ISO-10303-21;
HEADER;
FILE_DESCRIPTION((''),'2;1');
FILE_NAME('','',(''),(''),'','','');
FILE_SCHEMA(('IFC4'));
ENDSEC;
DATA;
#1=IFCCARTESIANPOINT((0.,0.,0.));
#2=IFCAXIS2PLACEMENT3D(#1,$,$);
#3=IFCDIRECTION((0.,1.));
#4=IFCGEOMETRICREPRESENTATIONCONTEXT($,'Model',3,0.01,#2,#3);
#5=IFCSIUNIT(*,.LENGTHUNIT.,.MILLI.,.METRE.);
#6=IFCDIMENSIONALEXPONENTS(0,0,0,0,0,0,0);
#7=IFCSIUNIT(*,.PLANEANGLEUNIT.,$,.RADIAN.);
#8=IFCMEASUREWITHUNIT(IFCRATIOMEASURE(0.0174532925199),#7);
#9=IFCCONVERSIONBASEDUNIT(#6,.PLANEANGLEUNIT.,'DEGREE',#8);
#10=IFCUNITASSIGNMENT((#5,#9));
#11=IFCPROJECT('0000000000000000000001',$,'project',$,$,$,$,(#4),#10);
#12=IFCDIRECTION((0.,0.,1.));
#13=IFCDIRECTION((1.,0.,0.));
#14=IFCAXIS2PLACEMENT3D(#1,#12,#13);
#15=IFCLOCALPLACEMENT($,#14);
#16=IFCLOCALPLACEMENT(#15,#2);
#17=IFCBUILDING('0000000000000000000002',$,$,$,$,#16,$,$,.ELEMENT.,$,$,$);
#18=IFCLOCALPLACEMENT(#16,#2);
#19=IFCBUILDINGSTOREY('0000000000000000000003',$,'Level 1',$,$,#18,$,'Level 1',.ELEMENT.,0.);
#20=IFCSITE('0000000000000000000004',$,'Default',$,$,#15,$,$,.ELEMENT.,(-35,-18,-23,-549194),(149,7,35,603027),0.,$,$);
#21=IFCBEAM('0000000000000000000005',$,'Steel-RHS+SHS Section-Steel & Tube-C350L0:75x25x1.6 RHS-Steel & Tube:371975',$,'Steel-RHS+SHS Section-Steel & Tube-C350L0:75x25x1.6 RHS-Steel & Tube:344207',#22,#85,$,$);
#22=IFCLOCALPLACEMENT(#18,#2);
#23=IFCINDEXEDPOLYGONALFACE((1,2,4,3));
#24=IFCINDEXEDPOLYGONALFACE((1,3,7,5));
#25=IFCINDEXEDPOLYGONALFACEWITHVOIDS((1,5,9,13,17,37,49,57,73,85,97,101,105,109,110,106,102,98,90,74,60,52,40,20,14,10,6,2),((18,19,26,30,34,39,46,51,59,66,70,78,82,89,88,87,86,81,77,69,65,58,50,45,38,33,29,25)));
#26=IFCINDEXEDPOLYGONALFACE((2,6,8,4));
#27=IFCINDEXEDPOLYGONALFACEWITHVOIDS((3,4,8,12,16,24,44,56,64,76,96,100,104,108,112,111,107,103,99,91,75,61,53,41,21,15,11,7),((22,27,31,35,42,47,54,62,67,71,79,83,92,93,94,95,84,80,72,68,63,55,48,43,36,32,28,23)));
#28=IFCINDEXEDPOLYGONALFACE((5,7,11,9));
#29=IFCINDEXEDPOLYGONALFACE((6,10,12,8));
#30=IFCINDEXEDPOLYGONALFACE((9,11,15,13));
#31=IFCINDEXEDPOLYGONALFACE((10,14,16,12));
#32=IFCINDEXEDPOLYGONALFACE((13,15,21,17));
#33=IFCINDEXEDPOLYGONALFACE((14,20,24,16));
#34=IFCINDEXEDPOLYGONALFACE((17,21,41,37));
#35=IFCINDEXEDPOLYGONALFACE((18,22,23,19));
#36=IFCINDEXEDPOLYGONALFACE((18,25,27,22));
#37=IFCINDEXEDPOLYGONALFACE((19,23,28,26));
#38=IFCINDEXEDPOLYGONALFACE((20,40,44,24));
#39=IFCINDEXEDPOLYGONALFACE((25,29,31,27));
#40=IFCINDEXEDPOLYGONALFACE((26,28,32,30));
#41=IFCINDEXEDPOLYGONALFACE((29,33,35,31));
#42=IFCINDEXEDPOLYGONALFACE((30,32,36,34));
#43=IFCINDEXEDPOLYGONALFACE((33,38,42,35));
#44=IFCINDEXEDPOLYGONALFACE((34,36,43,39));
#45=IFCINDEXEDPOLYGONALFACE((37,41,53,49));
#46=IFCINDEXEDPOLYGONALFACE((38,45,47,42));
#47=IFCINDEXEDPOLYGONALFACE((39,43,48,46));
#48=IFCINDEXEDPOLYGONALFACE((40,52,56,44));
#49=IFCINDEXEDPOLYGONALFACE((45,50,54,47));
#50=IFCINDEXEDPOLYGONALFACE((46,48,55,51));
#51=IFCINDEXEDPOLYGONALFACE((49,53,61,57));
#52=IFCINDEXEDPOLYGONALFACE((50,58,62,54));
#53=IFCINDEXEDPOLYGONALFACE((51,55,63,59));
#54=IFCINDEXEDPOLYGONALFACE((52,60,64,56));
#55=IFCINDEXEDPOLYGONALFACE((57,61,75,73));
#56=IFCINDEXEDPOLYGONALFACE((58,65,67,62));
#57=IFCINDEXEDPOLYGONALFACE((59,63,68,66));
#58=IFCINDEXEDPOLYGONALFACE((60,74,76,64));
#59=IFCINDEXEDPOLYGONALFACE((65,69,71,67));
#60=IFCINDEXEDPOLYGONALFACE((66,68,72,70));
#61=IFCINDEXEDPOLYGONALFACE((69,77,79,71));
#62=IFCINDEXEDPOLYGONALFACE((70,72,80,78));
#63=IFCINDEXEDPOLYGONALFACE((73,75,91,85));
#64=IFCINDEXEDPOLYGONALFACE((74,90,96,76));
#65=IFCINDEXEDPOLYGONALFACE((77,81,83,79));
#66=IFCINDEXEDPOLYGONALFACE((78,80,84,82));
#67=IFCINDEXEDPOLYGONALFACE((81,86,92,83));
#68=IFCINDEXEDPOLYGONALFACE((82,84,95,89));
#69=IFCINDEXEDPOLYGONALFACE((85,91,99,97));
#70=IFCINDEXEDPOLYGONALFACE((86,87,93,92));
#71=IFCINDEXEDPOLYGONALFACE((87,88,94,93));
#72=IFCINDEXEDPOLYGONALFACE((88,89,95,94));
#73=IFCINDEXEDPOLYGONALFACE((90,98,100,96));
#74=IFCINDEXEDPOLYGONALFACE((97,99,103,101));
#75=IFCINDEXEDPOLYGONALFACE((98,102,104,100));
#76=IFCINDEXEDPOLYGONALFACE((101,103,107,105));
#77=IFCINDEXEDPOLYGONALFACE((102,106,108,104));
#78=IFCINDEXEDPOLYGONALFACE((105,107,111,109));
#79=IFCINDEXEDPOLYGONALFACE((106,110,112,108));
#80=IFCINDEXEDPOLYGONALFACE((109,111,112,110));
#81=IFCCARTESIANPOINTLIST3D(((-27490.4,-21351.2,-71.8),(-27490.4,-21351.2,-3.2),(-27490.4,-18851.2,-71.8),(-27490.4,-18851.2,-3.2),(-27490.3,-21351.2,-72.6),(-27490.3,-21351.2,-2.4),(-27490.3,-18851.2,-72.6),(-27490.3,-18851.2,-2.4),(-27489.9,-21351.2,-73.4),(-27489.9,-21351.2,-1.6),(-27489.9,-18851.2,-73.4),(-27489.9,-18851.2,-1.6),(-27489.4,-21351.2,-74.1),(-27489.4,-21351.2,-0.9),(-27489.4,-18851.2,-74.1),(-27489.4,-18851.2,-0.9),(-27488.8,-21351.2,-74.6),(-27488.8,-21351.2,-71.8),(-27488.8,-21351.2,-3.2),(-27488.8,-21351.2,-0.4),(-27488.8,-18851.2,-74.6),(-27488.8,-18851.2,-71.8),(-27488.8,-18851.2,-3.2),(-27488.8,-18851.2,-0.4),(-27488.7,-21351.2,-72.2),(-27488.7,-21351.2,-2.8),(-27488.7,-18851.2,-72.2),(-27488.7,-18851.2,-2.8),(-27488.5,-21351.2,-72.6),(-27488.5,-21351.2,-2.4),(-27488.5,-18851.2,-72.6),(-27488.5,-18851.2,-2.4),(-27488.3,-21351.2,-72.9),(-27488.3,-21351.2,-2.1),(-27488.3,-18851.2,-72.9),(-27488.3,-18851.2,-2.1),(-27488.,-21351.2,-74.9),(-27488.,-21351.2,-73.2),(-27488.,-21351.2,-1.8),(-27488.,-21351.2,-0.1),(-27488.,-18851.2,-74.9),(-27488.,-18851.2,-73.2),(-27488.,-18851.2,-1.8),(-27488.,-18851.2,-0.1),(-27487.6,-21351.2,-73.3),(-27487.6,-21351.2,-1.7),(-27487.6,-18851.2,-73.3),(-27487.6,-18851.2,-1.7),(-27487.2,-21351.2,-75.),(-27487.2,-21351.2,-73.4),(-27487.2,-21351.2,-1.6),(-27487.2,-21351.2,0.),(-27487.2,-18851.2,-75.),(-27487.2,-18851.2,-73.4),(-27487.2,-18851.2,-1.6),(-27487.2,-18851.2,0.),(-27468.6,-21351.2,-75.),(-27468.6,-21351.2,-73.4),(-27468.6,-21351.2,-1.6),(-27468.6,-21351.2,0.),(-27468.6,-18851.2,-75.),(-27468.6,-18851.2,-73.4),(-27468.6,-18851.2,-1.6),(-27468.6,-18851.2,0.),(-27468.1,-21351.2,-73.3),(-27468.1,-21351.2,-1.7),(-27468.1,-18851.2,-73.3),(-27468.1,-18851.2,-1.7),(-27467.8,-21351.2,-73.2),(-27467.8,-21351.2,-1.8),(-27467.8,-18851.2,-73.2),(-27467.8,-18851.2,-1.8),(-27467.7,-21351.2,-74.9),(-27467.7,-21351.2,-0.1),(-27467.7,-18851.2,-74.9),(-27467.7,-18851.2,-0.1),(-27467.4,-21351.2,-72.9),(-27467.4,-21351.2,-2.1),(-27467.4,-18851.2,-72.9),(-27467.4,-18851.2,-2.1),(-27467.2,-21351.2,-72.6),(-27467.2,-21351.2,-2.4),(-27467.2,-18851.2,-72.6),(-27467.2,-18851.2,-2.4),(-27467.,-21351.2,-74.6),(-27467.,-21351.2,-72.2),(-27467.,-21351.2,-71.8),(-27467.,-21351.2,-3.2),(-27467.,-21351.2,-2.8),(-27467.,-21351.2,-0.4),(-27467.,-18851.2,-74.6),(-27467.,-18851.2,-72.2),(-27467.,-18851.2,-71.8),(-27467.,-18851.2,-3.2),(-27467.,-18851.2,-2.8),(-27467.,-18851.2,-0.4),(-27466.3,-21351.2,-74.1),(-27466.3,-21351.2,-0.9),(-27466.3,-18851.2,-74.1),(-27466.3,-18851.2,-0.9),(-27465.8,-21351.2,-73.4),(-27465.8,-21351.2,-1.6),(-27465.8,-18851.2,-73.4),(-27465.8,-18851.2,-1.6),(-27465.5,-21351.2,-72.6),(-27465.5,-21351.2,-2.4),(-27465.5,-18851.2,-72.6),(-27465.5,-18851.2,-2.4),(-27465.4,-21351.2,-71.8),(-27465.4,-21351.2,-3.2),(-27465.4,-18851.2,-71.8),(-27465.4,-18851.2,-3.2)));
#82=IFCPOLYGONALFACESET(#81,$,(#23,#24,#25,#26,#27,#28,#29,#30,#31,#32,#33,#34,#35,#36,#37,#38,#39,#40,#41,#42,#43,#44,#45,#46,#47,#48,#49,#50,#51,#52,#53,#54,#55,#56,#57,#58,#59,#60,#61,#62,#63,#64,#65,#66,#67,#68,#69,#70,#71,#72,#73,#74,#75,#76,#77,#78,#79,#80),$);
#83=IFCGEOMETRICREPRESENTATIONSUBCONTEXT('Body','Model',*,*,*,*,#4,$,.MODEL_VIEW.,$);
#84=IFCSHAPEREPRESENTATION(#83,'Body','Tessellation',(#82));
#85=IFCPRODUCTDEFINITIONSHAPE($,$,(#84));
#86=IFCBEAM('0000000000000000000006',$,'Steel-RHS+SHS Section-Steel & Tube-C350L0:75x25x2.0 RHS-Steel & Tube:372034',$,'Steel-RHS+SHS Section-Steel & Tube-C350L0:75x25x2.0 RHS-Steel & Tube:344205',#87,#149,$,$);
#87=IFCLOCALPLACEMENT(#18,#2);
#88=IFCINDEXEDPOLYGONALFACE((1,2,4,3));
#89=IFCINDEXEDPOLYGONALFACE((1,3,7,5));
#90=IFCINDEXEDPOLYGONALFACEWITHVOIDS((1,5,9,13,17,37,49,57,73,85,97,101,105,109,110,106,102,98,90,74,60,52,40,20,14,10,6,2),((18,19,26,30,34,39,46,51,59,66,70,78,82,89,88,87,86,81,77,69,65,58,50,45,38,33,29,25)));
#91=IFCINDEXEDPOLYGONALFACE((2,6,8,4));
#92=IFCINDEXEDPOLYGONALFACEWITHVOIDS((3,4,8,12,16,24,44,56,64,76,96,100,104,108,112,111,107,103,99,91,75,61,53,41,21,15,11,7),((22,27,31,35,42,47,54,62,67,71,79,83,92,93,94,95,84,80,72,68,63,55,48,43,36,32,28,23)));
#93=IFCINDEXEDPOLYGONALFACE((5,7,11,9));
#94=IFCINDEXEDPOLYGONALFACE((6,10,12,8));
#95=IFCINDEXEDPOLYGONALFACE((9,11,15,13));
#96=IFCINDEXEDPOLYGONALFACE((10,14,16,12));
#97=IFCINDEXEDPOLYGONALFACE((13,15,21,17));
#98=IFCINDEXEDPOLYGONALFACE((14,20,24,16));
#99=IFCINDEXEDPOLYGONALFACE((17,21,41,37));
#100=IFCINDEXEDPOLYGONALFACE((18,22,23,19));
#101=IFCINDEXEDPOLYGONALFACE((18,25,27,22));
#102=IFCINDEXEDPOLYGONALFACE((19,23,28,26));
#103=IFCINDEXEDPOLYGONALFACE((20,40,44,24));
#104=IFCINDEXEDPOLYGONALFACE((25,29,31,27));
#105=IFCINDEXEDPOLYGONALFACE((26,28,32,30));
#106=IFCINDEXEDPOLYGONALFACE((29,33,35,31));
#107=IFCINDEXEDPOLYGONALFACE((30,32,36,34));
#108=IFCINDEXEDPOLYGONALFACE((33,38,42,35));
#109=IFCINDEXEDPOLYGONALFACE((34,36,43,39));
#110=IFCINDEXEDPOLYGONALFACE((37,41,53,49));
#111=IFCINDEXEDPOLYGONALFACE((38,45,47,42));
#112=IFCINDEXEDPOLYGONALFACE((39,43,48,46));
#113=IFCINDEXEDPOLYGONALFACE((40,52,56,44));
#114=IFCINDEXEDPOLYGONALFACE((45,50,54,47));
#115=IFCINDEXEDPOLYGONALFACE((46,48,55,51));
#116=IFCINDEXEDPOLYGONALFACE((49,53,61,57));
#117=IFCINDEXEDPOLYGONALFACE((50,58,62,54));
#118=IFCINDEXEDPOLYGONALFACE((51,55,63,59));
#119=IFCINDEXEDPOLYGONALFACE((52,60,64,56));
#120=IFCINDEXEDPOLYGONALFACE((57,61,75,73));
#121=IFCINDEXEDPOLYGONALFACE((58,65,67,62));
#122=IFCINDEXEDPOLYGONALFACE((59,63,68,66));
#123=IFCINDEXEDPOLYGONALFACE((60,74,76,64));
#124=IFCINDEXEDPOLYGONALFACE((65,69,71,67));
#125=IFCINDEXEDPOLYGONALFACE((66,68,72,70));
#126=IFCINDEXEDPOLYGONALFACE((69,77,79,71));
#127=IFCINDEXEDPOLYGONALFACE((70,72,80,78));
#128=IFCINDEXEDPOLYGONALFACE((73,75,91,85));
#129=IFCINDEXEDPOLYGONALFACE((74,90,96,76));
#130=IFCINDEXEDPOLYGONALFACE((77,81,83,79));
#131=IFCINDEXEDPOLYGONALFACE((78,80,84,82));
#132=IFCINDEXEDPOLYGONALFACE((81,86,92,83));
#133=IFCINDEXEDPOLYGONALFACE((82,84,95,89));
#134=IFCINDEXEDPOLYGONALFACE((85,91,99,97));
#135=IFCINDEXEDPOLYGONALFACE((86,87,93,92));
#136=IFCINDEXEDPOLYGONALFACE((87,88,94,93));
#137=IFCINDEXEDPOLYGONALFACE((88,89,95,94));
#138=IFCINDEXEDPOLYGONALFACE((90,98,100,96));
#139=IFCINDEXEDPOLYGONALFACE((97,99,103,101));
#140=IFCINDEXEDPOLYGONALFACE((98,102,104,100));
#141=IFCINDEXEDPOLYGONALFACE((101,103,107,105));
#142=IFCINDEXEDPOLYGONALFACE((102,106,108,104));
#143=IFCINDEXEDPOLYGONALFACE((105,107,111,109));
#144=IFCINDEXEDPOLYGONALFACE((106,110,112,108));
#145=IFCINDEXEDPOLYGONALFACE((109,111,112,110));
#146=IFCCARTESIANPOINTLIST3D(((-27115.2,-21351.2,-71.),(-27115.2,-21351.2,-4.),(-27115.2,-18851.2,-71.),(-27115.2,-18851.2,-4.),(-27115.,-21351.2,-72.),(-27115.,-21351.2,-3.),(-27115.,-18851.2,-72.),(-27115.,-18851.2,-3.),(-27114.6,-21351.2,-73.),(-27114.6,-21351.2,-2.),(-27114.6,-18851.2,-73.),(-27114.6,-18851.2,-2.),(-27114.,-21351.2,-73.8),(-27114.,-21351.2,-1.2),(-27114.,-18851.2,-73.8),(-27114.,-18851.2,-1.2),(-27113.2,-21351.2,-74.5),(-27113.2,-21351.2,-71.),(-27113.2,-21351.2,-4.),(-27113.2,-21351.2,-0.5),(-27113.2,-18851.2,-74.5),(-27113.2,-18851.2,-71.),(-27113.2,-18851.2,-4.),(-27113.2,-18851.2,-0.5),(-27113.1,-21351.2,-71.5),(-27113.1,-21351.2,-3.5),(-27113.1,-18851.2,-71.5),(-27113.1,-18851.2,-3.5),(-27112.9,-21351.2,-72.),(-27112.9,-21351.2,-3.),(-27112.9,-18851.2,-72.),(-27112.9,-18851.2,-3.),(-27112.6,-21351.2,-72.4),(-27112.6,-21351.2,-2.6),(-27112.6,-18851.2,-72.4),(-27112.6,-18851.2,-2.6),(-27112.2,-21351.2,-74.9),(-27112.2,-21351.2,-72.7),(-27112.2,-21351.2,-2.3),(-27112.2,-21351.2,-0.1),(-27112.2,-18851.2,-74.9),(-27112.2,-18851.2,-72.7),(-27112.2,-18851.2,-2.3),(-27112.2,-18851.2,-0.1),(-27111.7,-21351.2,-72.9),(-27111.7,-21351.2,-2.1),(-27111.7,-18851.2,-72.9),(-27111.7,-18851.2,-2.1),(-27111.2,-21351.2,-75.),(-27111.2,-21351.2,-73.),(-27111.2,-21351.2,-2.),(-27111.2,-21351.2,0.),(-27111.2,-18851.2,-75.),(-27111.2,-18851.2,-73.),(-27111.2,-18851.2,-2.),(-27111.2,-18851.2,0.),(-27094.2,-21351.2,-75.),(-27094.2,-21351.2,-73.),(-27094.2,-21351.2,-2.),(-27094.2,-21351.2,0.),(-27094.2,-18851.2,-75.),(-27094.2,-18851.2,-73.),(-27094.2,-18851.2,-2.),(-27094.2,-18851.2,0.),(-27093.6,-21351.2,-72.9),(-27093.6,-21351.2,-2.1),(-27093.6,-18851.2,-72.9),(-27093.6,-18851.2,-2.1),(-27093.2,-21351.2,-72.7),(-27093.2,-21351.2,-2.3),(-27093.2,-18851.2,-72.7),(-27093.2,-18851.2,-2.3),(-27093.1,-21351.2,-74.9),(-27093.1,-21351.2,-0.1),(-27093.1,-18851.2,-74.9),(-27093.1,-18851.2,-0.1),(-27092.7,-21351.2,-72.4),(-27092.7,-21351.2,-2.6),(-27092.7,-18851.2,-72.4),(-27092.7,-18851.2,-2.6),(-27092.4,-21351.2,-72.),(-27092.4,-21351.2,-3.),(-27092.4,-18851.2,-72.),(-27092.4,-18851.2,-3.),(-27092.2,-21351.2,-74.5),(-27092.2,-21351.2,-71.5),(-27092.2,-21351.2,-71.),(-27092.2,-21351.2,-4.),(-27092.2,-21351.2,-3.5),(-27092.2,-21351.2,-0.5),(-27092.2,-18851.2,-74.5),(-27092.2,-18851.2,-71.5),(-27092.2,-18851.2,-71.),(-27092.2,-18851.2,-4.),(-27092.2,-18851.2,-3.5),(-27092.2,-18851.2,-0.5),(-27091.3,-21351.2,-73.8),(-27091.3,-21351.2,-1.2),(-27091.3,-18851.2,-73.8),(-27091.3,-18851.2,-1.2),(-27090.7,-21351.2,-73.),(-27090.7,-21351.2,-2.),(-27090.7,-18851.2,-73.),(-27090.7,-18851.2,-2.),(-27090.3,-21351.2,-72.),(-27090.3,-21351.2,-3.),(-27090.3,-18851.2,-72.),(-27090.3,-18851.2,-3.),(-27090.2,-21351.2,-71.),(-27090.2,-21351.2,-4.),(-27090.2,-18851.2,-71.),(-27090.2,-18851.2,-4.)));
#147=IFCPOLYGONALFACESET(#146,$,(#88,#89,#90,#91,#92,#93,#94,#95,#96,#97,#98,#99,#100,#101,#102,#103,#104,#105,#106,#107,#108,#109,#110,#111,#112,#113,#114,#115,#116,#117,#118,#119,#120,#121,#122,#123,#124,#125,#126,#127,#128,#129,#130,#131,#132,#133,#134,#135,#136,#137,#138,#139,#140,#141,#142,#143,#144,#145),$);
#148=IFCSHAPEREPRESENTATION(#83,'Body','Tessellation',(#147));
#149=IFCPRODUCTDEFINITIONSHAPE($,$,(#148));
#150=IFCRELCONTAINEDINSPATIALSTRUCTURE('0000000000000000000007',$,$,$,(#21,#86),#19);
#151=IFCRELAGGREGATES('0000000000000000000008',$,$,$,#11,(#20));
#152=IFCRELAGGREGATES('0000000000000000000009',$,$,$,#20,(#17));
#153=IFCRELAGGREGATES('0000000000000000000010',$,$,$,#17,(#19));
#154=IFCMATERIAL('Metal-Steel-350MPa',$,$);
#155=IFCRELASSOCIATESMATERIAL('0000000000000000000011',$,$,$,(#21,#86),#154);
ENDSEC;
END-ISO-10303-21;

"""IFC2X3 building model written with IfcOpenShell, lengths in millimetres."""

from ifc_helpers import new_model, entity, si_unit, converted_unit, direction, frame, frame_2d, origin, origin_with_axes, place, context, subcontext, project, spatial, polyline, circle_curve, parameter, trimmed, segment, composite_curve, outline, extrude, material, element, save


model = new_model("IFC2X3")

# Units and contexts
model_context = context("Model", 3, precision=0.01, world=origin(), true_north=direction((0.0, 1.0)))
body_context = subcontext(model_context, "Body", "Model", "MODEL_VIEW")
ifc_project = project(units=[si_unit("LENGTHUNIT", "METRE", prefix="MILLI"), converted_unit("PLANEANGLEUNIT", "DEGREE", entity("IfcRatioMeasure", 0.0174532925199), si_unit("PLANEANGLEUNIT", "RADIAN"), dimensions=[0, 0, 0, 0, 0, 0, 0])], contexts=[model_context])

# Site, building, storey
site_placement = place(None, origin_with_axes())
site = spatial("IfcSite", under=ifc_project, at=site_placement, Name="Default", CompositionType="ELEMENT", RefLatitude=(-35, -18, -23, -549194), RefLongitude=(149, 7, 35, 603027), RefElevation=0.0)
building_placement = place(site_placement, origin())
building = spatial("IfcBuilding", under=site, at=building_placement, CompositionType="ELEMENT")
storey_placement = place(building_placement, origin())
storey = spatial("IfcBuildingStorey", under=building, at=storey_placement, Name="Level 1", LongName="Level 1", CompositionType="ELEMENT", Elevation=0.0)

# Beams
ifc_material = material(Name="Metal-Steel-350MPa")
beam_1_placement = place(storey_placement, frame((-27477.9, -18851.2, 0.0), z_axis=(0.0, 0.0, 1.0), x_axis=(0.0, -1.0, 0.0)))
element("IfcBeam", 1, at=beam_1_placement, inside=storey, material=ifc_material, Name="Steel-RHS+SHS Section-Steel & Tube-C350L0:75x25x1.6 RHS-Steel & Tube:371975", ObjectType="Steel-RHS+SHS Section-Steel & Tube-C350L0:75x25x1.6 RHS-Steel & Tube:344207", context=body_context, shape_type="SweptSolid", body=[
    extrude(outline(composite_curve([segment(trimmed(circle_curve(frame_2d((-9.3, -34.3), x_axis=(1.0, 0.0)), 3.2), [parameter(180.0)], [parameter(270.0)], True, "PARAMETER"), True, "CONTINUOUS"), segment(polyline([(-9.3, -37.5), (9.3, -37.5)]), True, "CONTINUOUS"), segment(trimmed(circle_curve(frame_2d((9.3, -34.3), x_axis=(1.0, 0.0)), 3.2), [parameter(270.0)], [parameter(0.0)], True, "PARAMETER"), True, "CONTINUOUS"), segment(polyline([(12.5, -34.3), (12.5, 34.3)]), True, "CONTINUOUS"), segment(trimmed(circle_curve(frame_2d((9.3, 34.3), x_axis=(1.0, 0.0)), 3.2), [parameter(0.0)], [parameter(90.0)], True, "PARAMETER"), True, "CONTINUOUS"), segment(polyline([(9.3, 37.5), (-9.3, 37.5)]), True, "CONTINUOUS"), segment(trimmed(circle_curve(frame_2d((-9.3, 34.3), x_axis=(1.0, 0.0)), 3.2), [parameter(90.0)], [parameter(180.0)], True, "PARAMETER"), True, "CONTINUOUS"), segment(polyline([(-12.5, 34.3), (-12.5, -34.3)]), True, "CONTINUOUS")], self_intersect=False), holes=[composite_curve([segment(polyline([(9.3, -35.9), (-9.3, -35.9)]), True, "CONTINUOUS"), segment(trimmed(circle_curve(frame_2d((-9.3, -34.3), x_axis=(1.0, 0.0)), 1.6), [parameter(180.0)], [parameter(270.0)], True, "PARAMETER"), False, "CONTINUOUS"), segment(polyline([(-10.9, -34.3), (-10.9, 34.3)]), True, "CONTINUOUS"), segment(trimmed(circle_curve(frame_2d((-9.3, 34.3), x_axis=(1.0, 0.0)), 1.6), [parameter(90.0)], [parameter(180.0)], True, "PARAMETER"), False, "CONTINUOUS"), segment(polyline([(-9.3, 35.9), (9.3, 35.9)]), True, "CONTINUOUS"), segment(trimmed(circle_curve(frame_2d((9.3, 34.3), x_axis=(1.0, 0.0)), 1.6), [parameter(360.0)], [parameter(90.0)], True, "PARAMETER"), False, "CONTINUOUS"), segment(polyline([(10.9, 34.3), (10.9, -34.3)]), True, "CONTINUOUS"), segment(trimmed(circle_curve(frame_2d((9.3, -34.3), x_axis=(1.0, 0.0)), 1.6), [parameter(270.0)], [parameter(0.0)], True, "PARAMETER"), False, "CONTINUOUS")], self_intersect=False)]), frame((0.0, 0.0, -37.5), z_axis=(1.0, 0.0, 0.0), x_axis=(0.0, -1.0, 0.0)), (0.0, 0.0, 1.0), 2500.0),
])
beam_2_placement = place(storey_placement, frame((-27102.7, -18851.2, 0.0), z_axis=(0.0, 0.0, 1.0), x_axis=(0.0, -1.0, 0.0)))
element("IfcBeam", 2, at=beam_2_placement, inside=storey, material=ifc_material, Name="Steel-RHS+SHS Section-Steel & Tube-C350L0:75x25x2.0 RHS-Steel & Tube:372034", ObjectType="Steel-RHS+SHS Section-Steel & Tube-C350L0:75x25x2.0 RHS-Steel & Tube:344205", context=body_context, shape_type="SweptSolid", body=[
    extrude(outline(composite_curve([segment(trimmed(circle_curve(frame_2d((-8.5, -33.5), x_axis=(1.0, 0.0)), 4.0), [parameter(180.0)], [parameter(270.0)], True, "PARAMETER"), True, "CONTINUOUS"), segment(polyline([(-8.5, -37.5), (8.5, -37.5)]), True, "CONTINUOUS"), segment(trimmed(circle_curve(frame_2d((8.5, -33.5), x_axis=(1.0, 0.0)), 4.0), [parameter(270.0)], [parameter(0.0)], True, "PARAMETER"), True, "CONTINUOUS"), segment(polyline([(12.5, -33.5), (12.5, 33.5)]), True, "CONTINUOUS"), segment(trimmed(circle_curve(frame_2d((8.5, 33.5), x_axis=(1.0, 0.0)), 4.0), [parameter(0.0)], [parameter(90.0)], True, "PARAMETER"), True, "CONTINUOUS"), segment(polyline([(8.5, 37.5), (-8.5, 37.5)]), True, "CONTINUOUS"), segment(trimmed(circle_curve(frame_2d((-8.5, 33.5), x_axis=(1.0, 0.0)), 4.0), [parameter(90.0)], [parameter(180.0)], True, "PARAMETER"), True, "CONTINUOUS"), segment(polyline([(-12.5, 33.5), (-12.5, -33.5)]), True, "CONTINUOUS")], self_intersect=False), holes=[composite_curve([segment(polyline([(8.5, -35.5), (-8.5, -35.5)]), True, "CONTINUOUS"), segment(trimmed(circle_curve(frame_2d((-8.5, -33.5), x_axis=(1.0, 0.0)), 2.0), [parameter(180.0)], [parameter(270.0)], True, "PARAMETER"), False, "CONTINUOUS"), segment(polyline([(-10.5, -33.5), (-10.5, 33.5)]), True, "CONTINUOUS"), segment(trimmed(circle_curve(frame_2d((-8.5, 33.5), x_axis=(1.0, 0.0)), 2.0), [parameter(90.0)], [parameter(180.0)], True, "PARAMETER"), False, "CONTINUOUS"), segment(polyline([(-8.5, 35.5), (8.5, 35.5)]), True, "CONTINUOUS"), segment(trimmed(circle_curve(frame_2d((8.5, 33.5), x_axis=(1.0, 0.0)), 2.0), [parameter(360.0)], [parameter(90.0)], True, "PARAMETER"), False, "CONTINUOUS"), segment(polyline([(10.5, 33.5), (10.5, -33.5)]), True, "CONTINUOUS"), segment(trimmed(circle_curve(frame_2d((8.5, -33.5), x_axis=(1.0, 0.0)), 2.0), [parameter(270.0)], [parameter(0.0)], True, "PARAMETER"), False, "CONTINUOUS")], self_intersect=False)]), frame((0.0, 0.0, -37.5), z_axis=(1.0, 0.0, 0.0), x_axis=(0.0, -1.0, 0.0)), (0.0, 0.0, 1.0), 2500.0),
])

save(model, "model.ifc")
